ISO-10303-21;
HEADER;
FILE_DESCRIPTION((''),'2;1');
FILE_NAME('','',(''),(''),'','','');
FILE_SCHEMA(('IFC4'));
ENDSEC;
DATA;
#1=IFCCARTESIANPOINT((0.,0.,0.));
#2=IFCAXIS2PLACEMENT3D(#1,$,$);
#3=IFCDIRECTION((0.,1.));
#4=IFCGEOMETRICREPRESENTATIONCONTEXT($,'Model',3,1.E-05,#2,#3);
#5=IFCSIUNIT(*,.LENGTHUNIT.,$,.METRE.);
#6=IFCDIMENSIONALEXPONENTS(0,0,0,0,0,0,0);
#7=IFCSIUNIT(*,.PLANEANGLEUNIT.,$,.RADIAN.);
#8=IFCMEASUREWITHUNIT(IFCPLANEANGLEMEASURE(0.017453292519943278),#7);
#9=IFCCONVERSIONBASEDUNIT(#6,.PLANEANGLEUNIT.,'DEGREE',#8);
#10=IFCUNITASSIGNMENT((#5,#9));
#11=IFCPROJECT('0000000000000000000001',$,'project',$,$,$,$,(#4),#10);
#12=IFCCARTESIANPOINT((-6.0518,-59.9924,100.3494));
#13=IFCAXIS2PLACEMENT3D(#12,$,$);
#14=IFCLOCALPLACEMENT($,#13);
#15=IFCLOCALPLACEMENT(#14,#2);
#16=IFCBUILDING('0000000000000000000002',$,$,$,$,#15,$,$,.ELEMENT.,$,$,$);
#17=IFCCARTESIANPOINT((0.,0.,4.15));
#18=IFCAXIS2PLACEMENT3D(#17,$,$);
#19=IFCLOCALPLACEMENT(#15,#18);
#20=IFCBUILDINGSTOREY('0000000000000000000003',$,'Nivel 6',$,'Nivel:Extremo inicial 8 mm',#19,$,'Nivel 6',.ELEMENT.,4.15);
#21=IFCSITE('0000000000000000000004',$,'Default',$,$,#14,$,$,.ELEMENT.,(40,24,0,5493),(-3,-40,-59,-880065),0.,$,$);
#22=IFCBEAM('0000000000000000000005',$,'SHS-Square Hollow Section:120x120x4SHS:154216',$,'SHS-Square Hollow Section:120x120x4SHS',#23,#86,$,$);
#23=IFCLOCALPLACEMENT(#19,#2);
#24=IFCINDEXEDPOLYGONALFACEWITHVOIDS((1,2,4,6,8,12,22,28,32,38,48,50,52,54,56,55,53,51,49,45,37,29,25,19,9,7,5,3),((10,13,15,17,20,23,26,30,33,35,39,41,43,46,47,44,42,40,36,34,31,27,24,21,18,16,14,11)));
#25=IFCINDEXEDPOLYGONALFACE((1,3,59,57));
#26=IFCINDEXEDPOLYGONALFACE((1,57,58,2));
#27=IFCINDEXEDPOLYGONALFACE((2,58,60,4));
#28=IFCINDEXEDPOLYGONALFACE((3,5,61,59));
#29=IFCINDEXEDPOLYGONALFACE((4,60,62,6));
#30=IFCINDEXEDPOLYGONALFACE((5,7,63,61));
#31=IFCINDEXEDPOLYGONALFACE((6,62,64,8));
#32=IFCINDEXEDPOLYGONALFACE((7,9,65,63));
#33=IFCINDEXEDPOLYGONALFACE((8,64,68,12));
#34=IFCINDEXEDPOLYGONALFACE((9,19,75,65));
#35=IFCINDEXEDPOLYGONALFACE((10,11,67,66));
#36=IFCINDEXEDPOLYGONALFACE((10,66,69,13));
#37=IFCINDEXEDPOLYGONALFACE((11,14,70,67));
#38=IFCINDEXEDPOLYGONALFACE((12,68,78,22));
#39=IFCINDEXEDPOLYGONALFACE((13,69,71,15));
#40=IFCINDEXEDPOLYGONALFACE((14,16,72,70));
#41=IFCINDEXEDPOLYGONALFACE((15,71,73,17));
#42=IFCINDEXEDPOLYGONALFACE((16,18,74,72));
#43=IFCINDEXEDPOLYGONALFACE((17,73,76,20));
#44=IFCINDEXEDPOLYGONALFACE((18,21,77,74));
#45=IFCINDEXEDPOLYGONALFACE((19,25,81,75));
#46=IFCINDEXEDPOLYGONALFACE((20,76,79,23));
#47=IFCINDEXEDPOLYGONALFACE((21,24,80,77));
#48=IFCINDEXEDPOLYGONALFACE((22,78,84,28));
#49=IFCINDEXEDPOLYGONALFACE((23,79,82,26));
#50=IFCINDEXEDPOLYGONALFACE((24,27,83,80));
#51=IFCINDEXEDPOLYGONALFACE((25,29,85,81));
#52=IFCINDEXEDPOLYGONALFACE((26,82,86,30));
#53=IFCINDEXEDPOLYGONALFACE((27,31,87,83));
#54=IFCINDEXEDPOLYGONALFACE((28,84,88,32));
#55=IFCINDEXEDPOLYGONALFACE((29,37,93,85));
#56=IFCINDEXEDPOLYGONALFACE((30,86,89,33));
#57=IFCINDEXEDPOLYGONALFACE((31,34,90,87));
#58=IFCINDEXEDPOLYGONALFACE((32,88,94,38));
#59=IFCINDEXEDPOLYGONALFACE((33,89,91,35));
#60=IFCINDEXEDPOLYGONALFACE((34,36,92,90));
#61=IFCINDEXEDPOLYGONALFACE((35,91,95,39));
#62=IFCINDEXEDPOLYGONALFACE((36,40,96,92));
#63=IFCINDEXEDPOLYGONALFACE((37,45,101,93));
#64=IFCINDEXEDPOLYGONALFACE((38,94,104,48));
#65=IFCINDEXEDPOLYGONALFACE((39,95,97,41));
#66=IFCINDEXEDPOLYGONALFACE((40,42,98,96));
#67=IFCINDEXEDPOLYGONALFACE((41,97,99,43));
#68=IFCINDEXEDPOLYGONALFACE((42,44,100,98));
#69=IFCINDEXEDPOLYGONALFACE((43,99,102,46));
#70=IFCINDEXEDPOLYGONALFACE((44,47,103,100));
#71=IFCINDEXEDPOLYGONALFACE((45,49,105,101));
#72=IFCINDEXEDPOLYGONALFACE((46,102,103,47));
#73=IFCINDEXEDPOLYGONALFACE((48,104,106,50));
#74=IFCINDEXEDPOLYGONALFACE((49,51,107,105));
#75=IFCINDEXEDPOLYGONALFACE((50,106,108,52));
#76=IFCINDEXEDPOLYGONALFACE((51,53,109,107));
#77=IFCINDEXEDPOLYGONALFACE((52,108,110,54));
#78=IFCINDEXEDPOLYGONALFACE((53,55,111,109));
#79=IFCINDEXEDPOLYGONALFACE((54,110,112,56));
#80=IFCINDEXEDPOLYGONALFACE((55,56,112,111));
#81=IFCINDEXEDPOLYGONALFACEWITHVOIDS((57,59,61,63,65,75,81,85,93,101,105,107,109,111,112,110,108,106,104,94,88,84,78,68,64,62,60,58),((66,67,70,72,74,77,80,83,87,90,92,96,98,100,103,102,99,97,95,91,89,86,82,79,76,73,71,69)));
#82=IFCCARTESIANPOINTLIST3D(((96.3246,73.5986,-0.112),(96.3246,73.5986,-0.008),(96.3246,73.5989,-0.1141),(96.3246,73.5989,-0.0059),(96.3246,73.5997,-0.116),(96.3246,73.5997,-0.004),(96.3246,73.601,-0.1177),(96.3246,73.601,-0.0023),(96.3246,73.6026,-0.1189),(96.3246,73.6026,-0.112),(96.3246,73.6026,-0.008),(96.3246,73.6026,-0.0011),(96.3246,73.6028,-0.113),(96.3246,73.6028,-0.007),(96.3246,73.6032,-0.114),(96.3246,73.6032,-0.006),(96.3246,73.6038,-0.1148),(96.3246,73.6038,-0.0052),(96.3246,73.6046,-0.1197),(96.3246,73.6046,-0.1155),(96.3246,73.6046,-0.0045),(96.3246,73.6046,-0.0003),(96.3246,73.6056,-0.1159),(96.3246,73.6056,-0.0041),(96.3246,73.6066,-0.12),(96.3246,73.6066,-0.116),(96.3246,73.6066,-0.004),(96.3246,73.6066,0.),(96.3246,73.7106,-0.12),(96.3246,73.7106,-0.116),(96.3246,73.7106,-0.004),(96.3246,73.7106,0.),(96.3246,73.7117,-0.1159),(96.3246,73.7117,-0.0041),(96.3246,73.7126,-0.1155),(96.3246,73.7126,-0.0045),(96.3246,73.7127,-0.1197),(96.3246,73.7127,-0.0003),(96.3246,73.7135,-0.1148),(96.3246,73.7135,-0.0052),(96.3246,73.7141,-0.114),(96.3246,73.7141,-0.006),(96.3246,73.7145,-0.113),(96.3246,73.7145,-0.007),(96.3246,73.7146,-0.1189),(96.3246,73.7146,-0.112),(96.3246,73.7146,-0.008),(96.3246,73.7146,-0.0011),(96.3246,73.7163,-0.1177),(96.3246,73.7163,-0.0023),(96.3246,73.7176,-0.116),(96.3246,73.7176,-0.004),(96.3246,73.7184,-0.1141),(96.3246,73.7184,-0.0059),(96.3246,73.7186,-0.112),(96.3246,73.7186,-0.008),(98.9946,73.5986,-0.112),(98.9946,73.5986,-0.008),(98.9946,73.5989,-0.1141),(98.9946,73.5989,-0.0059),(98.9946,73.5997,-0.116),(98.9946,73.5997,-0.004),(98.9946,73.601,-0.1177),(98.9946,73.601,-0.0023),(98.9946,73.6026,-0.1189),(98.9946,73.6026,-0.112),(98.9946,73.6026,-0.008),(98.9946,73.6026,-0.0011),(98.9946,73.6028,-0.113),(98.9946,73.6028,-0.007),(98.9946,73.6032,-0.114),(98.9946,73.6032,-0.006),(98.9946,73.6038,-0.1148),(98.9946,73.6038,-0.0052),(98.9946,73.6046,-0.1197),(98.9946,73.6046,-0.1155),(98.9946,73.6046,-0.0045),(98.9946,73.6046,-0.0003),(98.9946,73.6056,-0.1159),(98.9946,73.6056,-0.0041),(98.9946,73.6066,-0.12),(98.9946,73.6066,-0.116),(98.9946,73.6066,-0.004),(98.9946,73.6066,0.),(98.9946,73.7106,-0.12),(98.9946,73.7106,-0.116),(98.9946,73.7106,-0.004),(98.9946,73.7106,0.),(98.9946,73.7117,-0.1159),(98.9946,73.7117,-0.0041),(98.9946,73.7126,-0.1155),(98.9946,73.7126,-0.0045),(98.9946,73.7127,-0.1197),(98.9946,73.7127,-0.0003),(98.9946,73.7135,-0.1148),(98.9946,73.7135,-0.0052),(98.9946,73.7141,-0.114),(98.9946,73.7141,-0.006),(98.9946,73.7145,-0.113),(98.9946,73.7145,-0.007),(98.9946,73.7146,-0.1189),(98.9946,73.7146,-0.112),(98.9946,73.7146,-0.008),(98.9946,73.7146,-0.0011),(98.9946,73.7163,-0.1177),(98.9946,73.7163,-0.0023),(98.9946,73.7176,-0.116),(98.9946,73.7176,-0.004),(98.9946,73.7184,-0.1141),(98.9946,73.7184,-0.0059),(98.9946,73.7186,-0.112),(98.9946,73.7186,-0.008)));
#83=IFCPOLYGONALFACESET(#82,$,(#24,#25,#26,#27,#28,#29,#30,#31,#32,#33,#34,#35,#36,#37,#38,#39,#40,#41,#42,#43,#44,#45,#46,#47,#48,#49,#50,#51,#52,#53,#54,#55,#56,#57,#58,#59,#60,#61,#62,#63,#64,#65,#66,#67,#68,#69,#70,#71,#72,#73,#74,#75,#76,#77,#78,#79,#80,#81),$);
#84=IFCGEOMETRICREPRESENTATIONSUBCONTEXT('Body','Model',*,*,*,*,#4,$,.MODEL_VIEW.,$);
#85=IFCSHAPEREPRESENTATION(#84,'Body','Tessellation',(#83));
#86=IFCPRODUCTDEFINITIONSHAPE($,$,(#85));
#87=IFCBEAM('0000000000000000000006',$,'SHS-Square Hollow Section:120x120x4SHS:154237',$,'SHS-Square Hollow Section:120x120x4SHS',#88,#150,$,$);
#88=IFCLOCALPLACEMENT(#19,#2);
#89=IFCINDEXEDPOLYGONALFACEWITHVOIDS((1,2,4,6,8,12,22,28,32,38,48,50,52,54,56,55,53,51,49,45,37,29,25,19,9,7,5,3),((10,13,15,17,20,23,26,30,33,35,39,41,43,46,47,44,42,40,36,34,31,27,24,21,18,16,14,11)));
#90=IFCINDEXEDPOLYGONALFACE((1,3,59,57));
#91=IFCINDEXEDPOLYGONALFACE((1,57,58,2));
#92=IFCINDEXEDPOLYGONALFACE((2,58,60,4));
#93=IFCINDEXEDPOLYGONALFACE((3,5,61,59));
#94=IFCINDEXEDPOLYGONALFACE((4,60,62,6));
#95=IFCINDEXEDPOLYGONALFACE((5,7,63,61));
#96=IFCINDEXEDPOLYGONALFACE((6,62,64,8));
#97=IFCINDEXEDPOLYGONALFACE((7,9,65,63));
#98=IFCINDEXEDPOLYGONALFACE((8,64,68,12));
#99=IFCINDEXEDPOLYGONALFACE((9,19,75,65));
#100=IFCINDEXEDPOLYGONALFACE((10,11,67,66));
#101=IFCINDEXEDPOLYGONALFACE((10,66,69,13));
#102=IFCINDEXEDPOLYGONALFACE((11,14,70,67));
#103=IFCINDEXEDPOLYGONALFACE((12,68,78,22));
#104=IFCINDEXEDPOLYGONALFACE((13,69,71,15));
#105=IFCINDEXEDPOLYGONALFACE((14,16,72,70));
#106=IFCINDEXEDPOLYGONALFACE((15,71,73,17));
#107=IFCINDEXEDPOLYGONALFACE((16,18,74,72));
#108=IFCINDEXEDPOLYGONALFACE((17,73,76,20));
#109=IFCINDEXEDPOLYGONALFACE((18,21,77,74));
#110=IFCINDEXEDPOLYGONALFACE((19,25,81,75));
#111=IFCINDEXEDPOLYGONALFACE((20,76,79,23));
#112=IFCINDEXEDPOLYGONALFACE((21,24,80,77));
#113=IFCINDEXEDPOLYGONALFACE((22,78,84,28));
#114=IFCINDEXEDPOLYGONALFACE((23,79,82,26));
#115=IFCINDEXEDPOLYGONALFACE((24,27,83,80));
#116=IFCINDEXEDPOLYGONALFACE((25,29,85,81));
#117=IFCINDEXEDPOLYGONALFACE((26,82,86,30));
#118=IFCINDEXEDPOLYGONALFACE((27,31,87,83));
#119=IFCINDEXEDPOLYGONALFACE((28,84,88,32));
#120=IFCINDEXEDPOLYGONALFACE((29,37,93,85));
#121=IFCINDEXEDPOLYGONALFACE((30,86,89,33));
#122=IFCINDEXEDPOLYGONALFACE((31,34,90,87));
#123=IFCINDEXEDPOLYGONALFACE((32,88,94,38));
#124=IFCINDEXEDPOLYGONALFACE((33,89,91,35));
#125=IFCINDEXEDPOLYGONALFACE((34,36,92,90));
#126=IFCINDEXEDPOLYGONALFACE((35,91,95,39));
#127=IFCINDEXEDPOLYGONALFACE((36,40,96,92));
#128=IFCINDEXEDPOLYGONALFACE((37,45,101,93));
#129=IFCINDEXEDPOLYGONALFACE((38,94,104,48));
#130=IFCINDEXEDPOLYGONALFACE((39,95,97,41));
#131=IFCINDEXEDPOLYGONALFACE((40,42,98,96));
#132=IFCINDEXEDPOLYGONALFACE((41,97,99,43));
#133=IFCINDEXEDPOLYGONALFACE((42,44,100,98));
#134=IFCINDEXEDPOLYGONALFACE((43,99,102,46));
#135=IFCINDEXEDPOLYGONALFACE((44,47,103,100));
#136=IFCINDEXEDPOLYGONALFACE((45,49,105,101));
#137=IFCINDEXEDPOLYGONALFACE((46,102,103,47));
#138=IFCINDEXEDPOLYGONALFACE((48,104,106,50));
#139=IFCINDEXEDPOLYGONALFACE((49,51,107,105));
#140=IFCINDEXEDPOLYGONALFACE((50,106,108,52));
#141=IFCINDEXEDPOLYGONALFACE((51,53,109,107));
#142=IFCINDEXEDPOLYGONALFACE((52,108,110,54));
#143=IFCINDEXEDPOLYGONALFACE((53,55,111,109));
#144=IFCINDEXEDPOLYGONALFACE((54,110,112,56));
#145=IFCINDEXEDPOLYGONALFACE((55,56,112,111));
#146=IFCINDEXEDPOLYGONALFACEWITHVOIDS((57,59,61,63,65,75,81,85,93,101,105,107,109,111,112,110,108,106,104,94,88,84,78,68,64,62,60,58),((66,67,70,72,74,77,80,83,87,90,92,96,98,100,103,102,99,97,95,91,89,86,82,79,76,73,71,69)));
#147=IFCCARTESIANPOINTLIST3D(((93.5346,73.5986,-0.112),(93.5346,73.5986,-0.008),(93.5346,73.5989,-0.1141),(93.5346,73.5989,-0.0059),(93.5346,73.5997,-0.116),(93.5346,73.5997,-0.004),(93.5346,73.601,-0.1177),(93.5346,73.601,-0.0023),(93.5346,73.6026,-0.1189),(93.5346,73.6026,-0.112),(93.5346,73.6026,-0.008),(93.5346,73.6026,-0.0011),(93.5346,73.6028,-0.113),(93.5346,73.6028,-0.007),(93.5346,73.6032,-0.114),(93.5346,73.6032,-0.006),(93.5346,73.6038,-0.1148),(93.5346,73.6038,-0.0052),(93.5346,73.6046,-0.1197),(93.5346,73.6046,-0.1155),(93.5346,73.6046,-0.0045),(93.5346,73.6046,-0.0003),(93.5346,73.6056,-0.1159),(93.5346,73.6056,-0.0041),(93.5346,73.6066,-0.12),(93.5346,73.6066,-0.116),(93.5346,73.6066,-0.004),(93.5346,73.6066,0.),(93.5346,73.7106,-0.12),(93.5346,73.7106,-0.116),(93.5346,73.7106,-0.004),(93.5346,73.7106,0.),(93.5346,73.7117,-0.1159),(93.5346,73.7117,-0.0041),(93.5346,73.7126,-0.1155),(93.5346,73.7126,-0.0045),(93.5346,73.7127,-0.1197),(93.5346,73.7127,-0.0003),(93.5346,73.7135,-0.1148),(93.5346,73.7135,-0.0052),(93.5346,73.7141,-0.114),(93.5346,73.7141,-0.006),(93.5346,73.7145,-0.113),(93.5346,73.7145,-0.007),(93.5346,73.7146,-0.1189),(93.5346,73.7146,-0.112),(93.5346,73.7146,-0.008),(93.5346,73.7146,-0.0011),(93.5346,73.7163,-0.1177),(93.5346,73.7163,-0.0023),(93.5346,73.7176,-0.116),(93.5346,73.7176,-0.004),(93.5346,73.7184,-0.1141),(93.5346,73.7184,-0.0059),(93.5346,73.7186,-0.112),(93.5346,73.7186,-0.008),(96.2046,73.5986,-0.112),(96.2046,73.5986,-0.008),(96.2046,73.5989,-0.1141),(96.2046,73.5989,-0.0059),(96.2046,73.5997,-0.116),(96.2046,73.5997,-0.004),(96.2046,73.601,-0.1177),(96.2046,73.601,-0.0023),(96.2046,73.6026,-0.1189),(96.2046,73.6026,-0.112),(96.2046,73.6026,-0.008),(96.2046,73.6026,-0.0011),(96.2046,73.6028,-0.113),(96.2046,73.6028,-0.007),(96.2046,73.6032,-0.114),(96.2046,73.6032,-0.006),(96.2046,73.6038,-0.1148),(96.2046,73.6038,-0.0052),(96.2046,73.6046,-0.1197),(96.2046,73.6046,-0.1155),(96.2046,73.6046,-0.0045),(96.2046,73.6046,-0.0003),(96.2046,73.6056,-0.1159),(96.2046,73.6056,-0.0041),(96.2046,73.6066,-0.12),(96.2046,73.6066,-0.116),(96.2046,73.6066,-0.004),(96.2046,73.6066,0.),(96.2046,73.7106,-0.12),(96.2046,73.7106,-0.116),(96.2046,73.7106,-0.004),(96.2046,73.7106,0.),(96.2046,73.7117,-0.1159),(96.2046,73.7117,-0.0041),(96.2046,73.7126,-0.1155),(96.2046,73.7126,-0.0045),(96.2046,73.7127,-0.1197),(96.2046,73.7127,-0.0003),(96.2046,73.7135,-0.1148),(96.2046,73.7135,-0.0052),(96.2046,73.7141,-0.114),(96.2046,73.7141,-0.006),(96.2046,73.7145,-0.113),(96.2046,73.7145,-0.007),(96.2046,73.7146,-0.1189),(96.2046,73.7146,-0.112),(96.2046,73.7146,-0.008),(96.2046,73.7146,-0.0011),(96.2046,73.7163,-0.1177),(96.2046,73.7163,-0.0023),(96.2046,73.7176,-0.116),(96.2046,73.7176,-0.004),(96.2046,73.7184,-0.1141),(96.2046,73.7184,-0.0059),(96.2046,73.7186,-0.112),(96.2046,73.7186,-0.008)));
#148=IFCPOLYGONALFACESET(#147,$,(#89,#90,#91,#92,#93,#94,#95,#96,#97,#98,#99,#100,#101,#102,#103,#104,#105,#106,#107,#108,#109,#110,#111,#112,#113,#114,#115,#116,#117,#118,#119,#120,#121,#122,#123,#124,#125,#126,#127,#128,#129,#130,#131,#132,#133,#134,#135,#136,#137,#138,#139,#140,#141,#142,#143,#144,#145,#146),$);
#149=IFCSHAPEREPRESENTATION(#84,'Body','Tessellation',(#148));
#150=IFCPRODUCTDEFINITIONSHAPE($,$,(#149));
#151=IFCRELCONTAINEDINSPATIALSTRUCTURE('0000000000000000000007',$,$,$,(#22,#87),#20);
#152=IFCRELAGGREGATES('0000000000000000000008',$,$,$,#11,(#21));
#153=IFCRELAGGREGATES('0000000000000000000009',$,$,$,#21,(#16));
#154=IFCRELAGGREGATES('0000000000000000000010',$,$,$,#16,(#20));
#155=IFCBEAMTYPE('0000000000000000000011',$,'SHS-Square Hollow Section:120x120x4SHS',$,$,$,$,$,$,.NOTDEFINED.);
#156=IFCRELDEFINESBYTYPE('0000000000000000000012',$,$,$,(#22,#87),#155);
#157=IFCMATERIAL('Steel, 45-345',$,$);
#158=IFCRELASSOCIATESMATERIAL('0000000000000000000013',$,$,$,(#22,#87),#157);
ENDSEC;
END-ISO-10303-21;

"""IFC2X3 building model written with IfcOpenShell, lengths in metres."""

from ifc_helpers import new_model, entity, si_unit, converted_unit, direction, frame, frame_2d, origin, place, context, subcontext, project, spatial, polyline, circle_curve, parameter, trimmed, segment, composite_curve, outline, extrude, material, type_object, element, save


model = new_model("IFC2X3")

# Units and contexts
model_context = context("Model", 3, precision=1e-05, world=origin(), true_north=direction((0.0, 1.0)))
body_context = subcontext(model_context, "Body", "Model", "MODEL_VIEW")
ifc_project = project(units=[si_unit("LENGTHUNIT", "METRE"), converted_unit("PLANEANGLEUNIT", "DEGREE", entity("IfcPlaneAngleMeasure", 0.017453292519943278), si_unit("PLANEANGLEUNIT", "RADIAN"), dimensions=[0, 0, 0, 0, 0, 0, 0])], contexts=[model_context])

# Site, building, storey
site_placement = place(None, frame((-6.0518, -59.9924, 100.3494)))
site = spatial("IfcSite", under=ifc_project, at=site_placement, Name="Default", CompositionType="ELEMENT", RefLatitude=(40, 24, 0, 5493), RefLongitude=(-3, -40, -59, -880065), RefElevation=0.0)
building_placement = place(site_placement, origin())
building = spatial("IfcBuilding", under=site, at=building_placement, CompositionType="ELEMENT")
storey_placement = place(building_placement, frame((0.0, 0.0, 4.15)))
storey = spatial("IfcBuildingStorey", under=building, at=storey_placement, Name="Nivel 6", ObjectType="Nivel:Extremo inicial 8 mm", LongName="Nivel 6", CompositionType="ELEMENT", Elevation=4.15)

# Beams
ifc_material_1 = material(Name="Steel, 45-345")
beam_type = type_object("IfcBeamType", Name="SHS-Square Hollow Section:120x120x4SHS", PredefinedType="NOTDEFINED")
beam_1_placement = place(storey_placement, frame((99.0546, 73.6586, 0.0), z_axis=(0.0, 0.0, 1.0), x_axis=(-1.0, 0.0, 0.0)))
element("IfcBeam", 1, at=beam_1_placement, inside=storey, type_object=beam_type, material=ifc_material_1, Name="SHS-Square Hollow Section:120x120x4SHS:154216", ObjectType="SHS-Square Hollow Section:120x120x4SHS", context=body_context, shape_type="SweptSolid", body=[
    extrude(outline(composite_curve([segment(trimmed(circle_curve(frame_2d((-0.052, -0.052), x_axis=(1.0, 0.0)), 0.008), [parameter(180.0)], [parameter(270.0)], True, "PARAMETER"), True, "CONTINUOUS"), segment(polyline([(-0.052, -0.06), (0.052, -0.06)]), True, "CONTINUOUS"), segment(trimmed(circle_curve(frame_2d((0.052, -0.052), x_axis=(1.0, 0.0)), 0.008), [parameter(270.0)], [parameter(0.0)], True, "PARAMETER"), True, "CONTINUOUS"), segment(polyline([(0.06, -0.052), (0.06, 0.052)]), True, "CONTINUOUS"), segment(trimmed(circle_curve(frame_2d((0.052, 0.052), x_axis=(1.0, 0.0)), 0.008), [parameter(360.0)], [parameter(90.0)], True, "PARAMETER"), True, "CONTINUOUS"), segment(polyline([(0.052, 0.06), (-0.052, 0.06)]), True, "CONTINUOUS"), segment(trimmed(circle_curve(frame_2d((-0.052, 0.052), x_axis=(1.0, 0.0)), 0.008), [parameter(90.0)], [parameter(180.0)], True, "PARAMETER"), True, "CONTINUOUS"), segment(polyline([(-0.06, 0.052), (-0.06, -0.052)]), True, "CONTINUOUS")], self_intersect=False), holes=[composite_curve([segment(polyline([(0.052, -0.056), (-0.052, -0.056)]), True, "CONTINUOUS"), segment(trimmed(circle_curve(frame_2d((-0.052, -0.052), x_axis=(1.0, 0.0)), 0.004), [parameter(180.0)], [parameter(270.0)], True, "PARAMETER"), False, "CONTINUOUS"), segment(polyline([(-0.056, -0.052), (-0.056, 0.052)]), True, "CONTINUOUS"), segment(trimmed(circle_curve(frame_2d((-0.052, 0.052), x_axis=(1.0, 0.0)), 0.004), [parameter(90.0)], [parameter(180.0)], True, "PARAMETER"), False, "CONTINUOUS"), segment(polyline([(-0.052, 0.056), (0.052, 0.056)]), True, "CONTINUOUS"), segment(trimmed(circle_curve(frame_2d((0.052, 0.052), x_axis=(1.0, 0.0)), 0.004), [parameter(0.0)], [parameter(90.0)], True, "PARAMETER"), False, "CONTINUOUS"), segment(polyline([(0.056, 0.052), (0.056, -0.052)]), True, "CONTINUOUS"), segment(trimmed(circle_curve(frame_2d((0.052, -0.052), x_axis=(1.0, 0.0)), 0.004), [parameter(270.0)], [parameter(0.0)], True, "PARAMETER"), False, "CONTINUOUS")], self_intersect=False)]), frame((0.06, 0.0, -0.06), z_axis=(1.0, 0.0, 0.0), x_axis=(0.0, -1.0, 0.0)), (0.0, 0.0, 1.0), 2.67),
])
beam_2_placement = place(storey_placement, frame((96.2646, 73.6586, 0.0), z_axis=(0.0, 0.0, 1.0), x_axis=(-1.0, 0.0, 0.0)))
element("IfcBeam", 2, at=beam_2_placement, inside=storey, type_object=beam_type, material=ifc_material_1, Name="SHS-Square Hollow Section:120x120x4SHS:154237", ObjectType="SHS-Square Hollow Section:120x120x4SHS", context=body_context, shape_type="SweptSolid", body=[
    extrude(outline(composite_curve([segment(trimmed(circle_curve(frame_2d((-0.052, -0.052), x_axis=(1.0, 0.0)), 0.008), [parameter(180.0)], [parameter(270.0)], True, "PARAMETER"), True, "CONTINUOUS"), segment(polyline([(-0.052, -0.06), (0.052, -0.06)]), True, "CONTINUOUS"), segment(trimmed(circle_curve(frame_2d((0.052, -0.052), x_axis=(1.0, 0.0)), 0.008), [parameter(270.0)], [parameter(0.0)], True, "PARAMETER"), True, "CONTINUOUS"), segment(polyline([(0.06, -0.052), (0.06, 0.052)]), True, "CONTINUOUS"), segment(trimmed(circle_curve(frame_2d((0.052, 0.052), x_axis=(1.0, 0.0)), 0.008), [parameter(360.0)], [parameter(90.0)], True, "PARAMETER"), True, "CONTINUOUS"), segment(polyline([(0.052, 0.06), (-0.052, 0.06)]), True, "CONTINUOUS"), segment(trimmed(circle_curve(frame_2d((-0.052, 0.052), x_axis=(1.0, 0.0)), 0.008), [parameter(90.0)], [parameter(180.0)], True, "PARAMETER"), True, "CONTINUOUS"), segment(polyline([(-0.06, 0.052), (-0.06, -0.052)]), True, "CONTINUOUS")], self_intersect=False), holes=[composite_curve([segment(polyline([(0.052, -0.056), (-0.052, -0.056)]), True, "CONTINUOUS"), segment(trimmed(circle_curve(frame_2d((-0.052, -0.052), x_axis=(1.0, 0.0)), 0.004), [parameter(180.0)], [parameter(270.0)], True, "PARAMETER"), False, "CONTINUOUS"), segment(polyline([(-0.056, -0.052), (-0.056, 0.052)]), True, "CONTINUOUS"), segment(trimmed(circle_curve(frame_2d((-0.052, 0.052), x_axis=(1.0, 0.0)), 0.004), [parameter(90.0)], [parameter(180.0)], True, "PARAMETER"), False, "CONTINUOUS"), segment(polyline([(-0.052, 0.056), (0.052, 0.056)]), True, "CONTINUOUS"), segment(trimmed(circle_curve(frame_2d((0.052, 0.052), x_axis=(1.0, 0.0)), 0.004), [parameter(0.0)], [parameter(90.0)], True, "PARAMETER"), False, "CONTINUOUS"), segment(polyline([(0.056, 0.052), (0.056, -0.052)]), True, "CONTINUOUS"), segment(trimmed(circle_curve(frame_2d((0.052, -0.052), x_axis=(1.0, 0.0)), 0.004), [parameter(270.0)], [parameter(0.0)], True, "PARAMETER"), False, "CONTINUOUS")], self_intersect=False)]), frame((0.06, 0.0, -0.06), z_axis=(1.0, 0.0, 0.0), x_axis=(0.0, -1.0, 0.0)), (0.0, 0.0, 1.0), 2.67),
])

save(model, "model.ifc")
